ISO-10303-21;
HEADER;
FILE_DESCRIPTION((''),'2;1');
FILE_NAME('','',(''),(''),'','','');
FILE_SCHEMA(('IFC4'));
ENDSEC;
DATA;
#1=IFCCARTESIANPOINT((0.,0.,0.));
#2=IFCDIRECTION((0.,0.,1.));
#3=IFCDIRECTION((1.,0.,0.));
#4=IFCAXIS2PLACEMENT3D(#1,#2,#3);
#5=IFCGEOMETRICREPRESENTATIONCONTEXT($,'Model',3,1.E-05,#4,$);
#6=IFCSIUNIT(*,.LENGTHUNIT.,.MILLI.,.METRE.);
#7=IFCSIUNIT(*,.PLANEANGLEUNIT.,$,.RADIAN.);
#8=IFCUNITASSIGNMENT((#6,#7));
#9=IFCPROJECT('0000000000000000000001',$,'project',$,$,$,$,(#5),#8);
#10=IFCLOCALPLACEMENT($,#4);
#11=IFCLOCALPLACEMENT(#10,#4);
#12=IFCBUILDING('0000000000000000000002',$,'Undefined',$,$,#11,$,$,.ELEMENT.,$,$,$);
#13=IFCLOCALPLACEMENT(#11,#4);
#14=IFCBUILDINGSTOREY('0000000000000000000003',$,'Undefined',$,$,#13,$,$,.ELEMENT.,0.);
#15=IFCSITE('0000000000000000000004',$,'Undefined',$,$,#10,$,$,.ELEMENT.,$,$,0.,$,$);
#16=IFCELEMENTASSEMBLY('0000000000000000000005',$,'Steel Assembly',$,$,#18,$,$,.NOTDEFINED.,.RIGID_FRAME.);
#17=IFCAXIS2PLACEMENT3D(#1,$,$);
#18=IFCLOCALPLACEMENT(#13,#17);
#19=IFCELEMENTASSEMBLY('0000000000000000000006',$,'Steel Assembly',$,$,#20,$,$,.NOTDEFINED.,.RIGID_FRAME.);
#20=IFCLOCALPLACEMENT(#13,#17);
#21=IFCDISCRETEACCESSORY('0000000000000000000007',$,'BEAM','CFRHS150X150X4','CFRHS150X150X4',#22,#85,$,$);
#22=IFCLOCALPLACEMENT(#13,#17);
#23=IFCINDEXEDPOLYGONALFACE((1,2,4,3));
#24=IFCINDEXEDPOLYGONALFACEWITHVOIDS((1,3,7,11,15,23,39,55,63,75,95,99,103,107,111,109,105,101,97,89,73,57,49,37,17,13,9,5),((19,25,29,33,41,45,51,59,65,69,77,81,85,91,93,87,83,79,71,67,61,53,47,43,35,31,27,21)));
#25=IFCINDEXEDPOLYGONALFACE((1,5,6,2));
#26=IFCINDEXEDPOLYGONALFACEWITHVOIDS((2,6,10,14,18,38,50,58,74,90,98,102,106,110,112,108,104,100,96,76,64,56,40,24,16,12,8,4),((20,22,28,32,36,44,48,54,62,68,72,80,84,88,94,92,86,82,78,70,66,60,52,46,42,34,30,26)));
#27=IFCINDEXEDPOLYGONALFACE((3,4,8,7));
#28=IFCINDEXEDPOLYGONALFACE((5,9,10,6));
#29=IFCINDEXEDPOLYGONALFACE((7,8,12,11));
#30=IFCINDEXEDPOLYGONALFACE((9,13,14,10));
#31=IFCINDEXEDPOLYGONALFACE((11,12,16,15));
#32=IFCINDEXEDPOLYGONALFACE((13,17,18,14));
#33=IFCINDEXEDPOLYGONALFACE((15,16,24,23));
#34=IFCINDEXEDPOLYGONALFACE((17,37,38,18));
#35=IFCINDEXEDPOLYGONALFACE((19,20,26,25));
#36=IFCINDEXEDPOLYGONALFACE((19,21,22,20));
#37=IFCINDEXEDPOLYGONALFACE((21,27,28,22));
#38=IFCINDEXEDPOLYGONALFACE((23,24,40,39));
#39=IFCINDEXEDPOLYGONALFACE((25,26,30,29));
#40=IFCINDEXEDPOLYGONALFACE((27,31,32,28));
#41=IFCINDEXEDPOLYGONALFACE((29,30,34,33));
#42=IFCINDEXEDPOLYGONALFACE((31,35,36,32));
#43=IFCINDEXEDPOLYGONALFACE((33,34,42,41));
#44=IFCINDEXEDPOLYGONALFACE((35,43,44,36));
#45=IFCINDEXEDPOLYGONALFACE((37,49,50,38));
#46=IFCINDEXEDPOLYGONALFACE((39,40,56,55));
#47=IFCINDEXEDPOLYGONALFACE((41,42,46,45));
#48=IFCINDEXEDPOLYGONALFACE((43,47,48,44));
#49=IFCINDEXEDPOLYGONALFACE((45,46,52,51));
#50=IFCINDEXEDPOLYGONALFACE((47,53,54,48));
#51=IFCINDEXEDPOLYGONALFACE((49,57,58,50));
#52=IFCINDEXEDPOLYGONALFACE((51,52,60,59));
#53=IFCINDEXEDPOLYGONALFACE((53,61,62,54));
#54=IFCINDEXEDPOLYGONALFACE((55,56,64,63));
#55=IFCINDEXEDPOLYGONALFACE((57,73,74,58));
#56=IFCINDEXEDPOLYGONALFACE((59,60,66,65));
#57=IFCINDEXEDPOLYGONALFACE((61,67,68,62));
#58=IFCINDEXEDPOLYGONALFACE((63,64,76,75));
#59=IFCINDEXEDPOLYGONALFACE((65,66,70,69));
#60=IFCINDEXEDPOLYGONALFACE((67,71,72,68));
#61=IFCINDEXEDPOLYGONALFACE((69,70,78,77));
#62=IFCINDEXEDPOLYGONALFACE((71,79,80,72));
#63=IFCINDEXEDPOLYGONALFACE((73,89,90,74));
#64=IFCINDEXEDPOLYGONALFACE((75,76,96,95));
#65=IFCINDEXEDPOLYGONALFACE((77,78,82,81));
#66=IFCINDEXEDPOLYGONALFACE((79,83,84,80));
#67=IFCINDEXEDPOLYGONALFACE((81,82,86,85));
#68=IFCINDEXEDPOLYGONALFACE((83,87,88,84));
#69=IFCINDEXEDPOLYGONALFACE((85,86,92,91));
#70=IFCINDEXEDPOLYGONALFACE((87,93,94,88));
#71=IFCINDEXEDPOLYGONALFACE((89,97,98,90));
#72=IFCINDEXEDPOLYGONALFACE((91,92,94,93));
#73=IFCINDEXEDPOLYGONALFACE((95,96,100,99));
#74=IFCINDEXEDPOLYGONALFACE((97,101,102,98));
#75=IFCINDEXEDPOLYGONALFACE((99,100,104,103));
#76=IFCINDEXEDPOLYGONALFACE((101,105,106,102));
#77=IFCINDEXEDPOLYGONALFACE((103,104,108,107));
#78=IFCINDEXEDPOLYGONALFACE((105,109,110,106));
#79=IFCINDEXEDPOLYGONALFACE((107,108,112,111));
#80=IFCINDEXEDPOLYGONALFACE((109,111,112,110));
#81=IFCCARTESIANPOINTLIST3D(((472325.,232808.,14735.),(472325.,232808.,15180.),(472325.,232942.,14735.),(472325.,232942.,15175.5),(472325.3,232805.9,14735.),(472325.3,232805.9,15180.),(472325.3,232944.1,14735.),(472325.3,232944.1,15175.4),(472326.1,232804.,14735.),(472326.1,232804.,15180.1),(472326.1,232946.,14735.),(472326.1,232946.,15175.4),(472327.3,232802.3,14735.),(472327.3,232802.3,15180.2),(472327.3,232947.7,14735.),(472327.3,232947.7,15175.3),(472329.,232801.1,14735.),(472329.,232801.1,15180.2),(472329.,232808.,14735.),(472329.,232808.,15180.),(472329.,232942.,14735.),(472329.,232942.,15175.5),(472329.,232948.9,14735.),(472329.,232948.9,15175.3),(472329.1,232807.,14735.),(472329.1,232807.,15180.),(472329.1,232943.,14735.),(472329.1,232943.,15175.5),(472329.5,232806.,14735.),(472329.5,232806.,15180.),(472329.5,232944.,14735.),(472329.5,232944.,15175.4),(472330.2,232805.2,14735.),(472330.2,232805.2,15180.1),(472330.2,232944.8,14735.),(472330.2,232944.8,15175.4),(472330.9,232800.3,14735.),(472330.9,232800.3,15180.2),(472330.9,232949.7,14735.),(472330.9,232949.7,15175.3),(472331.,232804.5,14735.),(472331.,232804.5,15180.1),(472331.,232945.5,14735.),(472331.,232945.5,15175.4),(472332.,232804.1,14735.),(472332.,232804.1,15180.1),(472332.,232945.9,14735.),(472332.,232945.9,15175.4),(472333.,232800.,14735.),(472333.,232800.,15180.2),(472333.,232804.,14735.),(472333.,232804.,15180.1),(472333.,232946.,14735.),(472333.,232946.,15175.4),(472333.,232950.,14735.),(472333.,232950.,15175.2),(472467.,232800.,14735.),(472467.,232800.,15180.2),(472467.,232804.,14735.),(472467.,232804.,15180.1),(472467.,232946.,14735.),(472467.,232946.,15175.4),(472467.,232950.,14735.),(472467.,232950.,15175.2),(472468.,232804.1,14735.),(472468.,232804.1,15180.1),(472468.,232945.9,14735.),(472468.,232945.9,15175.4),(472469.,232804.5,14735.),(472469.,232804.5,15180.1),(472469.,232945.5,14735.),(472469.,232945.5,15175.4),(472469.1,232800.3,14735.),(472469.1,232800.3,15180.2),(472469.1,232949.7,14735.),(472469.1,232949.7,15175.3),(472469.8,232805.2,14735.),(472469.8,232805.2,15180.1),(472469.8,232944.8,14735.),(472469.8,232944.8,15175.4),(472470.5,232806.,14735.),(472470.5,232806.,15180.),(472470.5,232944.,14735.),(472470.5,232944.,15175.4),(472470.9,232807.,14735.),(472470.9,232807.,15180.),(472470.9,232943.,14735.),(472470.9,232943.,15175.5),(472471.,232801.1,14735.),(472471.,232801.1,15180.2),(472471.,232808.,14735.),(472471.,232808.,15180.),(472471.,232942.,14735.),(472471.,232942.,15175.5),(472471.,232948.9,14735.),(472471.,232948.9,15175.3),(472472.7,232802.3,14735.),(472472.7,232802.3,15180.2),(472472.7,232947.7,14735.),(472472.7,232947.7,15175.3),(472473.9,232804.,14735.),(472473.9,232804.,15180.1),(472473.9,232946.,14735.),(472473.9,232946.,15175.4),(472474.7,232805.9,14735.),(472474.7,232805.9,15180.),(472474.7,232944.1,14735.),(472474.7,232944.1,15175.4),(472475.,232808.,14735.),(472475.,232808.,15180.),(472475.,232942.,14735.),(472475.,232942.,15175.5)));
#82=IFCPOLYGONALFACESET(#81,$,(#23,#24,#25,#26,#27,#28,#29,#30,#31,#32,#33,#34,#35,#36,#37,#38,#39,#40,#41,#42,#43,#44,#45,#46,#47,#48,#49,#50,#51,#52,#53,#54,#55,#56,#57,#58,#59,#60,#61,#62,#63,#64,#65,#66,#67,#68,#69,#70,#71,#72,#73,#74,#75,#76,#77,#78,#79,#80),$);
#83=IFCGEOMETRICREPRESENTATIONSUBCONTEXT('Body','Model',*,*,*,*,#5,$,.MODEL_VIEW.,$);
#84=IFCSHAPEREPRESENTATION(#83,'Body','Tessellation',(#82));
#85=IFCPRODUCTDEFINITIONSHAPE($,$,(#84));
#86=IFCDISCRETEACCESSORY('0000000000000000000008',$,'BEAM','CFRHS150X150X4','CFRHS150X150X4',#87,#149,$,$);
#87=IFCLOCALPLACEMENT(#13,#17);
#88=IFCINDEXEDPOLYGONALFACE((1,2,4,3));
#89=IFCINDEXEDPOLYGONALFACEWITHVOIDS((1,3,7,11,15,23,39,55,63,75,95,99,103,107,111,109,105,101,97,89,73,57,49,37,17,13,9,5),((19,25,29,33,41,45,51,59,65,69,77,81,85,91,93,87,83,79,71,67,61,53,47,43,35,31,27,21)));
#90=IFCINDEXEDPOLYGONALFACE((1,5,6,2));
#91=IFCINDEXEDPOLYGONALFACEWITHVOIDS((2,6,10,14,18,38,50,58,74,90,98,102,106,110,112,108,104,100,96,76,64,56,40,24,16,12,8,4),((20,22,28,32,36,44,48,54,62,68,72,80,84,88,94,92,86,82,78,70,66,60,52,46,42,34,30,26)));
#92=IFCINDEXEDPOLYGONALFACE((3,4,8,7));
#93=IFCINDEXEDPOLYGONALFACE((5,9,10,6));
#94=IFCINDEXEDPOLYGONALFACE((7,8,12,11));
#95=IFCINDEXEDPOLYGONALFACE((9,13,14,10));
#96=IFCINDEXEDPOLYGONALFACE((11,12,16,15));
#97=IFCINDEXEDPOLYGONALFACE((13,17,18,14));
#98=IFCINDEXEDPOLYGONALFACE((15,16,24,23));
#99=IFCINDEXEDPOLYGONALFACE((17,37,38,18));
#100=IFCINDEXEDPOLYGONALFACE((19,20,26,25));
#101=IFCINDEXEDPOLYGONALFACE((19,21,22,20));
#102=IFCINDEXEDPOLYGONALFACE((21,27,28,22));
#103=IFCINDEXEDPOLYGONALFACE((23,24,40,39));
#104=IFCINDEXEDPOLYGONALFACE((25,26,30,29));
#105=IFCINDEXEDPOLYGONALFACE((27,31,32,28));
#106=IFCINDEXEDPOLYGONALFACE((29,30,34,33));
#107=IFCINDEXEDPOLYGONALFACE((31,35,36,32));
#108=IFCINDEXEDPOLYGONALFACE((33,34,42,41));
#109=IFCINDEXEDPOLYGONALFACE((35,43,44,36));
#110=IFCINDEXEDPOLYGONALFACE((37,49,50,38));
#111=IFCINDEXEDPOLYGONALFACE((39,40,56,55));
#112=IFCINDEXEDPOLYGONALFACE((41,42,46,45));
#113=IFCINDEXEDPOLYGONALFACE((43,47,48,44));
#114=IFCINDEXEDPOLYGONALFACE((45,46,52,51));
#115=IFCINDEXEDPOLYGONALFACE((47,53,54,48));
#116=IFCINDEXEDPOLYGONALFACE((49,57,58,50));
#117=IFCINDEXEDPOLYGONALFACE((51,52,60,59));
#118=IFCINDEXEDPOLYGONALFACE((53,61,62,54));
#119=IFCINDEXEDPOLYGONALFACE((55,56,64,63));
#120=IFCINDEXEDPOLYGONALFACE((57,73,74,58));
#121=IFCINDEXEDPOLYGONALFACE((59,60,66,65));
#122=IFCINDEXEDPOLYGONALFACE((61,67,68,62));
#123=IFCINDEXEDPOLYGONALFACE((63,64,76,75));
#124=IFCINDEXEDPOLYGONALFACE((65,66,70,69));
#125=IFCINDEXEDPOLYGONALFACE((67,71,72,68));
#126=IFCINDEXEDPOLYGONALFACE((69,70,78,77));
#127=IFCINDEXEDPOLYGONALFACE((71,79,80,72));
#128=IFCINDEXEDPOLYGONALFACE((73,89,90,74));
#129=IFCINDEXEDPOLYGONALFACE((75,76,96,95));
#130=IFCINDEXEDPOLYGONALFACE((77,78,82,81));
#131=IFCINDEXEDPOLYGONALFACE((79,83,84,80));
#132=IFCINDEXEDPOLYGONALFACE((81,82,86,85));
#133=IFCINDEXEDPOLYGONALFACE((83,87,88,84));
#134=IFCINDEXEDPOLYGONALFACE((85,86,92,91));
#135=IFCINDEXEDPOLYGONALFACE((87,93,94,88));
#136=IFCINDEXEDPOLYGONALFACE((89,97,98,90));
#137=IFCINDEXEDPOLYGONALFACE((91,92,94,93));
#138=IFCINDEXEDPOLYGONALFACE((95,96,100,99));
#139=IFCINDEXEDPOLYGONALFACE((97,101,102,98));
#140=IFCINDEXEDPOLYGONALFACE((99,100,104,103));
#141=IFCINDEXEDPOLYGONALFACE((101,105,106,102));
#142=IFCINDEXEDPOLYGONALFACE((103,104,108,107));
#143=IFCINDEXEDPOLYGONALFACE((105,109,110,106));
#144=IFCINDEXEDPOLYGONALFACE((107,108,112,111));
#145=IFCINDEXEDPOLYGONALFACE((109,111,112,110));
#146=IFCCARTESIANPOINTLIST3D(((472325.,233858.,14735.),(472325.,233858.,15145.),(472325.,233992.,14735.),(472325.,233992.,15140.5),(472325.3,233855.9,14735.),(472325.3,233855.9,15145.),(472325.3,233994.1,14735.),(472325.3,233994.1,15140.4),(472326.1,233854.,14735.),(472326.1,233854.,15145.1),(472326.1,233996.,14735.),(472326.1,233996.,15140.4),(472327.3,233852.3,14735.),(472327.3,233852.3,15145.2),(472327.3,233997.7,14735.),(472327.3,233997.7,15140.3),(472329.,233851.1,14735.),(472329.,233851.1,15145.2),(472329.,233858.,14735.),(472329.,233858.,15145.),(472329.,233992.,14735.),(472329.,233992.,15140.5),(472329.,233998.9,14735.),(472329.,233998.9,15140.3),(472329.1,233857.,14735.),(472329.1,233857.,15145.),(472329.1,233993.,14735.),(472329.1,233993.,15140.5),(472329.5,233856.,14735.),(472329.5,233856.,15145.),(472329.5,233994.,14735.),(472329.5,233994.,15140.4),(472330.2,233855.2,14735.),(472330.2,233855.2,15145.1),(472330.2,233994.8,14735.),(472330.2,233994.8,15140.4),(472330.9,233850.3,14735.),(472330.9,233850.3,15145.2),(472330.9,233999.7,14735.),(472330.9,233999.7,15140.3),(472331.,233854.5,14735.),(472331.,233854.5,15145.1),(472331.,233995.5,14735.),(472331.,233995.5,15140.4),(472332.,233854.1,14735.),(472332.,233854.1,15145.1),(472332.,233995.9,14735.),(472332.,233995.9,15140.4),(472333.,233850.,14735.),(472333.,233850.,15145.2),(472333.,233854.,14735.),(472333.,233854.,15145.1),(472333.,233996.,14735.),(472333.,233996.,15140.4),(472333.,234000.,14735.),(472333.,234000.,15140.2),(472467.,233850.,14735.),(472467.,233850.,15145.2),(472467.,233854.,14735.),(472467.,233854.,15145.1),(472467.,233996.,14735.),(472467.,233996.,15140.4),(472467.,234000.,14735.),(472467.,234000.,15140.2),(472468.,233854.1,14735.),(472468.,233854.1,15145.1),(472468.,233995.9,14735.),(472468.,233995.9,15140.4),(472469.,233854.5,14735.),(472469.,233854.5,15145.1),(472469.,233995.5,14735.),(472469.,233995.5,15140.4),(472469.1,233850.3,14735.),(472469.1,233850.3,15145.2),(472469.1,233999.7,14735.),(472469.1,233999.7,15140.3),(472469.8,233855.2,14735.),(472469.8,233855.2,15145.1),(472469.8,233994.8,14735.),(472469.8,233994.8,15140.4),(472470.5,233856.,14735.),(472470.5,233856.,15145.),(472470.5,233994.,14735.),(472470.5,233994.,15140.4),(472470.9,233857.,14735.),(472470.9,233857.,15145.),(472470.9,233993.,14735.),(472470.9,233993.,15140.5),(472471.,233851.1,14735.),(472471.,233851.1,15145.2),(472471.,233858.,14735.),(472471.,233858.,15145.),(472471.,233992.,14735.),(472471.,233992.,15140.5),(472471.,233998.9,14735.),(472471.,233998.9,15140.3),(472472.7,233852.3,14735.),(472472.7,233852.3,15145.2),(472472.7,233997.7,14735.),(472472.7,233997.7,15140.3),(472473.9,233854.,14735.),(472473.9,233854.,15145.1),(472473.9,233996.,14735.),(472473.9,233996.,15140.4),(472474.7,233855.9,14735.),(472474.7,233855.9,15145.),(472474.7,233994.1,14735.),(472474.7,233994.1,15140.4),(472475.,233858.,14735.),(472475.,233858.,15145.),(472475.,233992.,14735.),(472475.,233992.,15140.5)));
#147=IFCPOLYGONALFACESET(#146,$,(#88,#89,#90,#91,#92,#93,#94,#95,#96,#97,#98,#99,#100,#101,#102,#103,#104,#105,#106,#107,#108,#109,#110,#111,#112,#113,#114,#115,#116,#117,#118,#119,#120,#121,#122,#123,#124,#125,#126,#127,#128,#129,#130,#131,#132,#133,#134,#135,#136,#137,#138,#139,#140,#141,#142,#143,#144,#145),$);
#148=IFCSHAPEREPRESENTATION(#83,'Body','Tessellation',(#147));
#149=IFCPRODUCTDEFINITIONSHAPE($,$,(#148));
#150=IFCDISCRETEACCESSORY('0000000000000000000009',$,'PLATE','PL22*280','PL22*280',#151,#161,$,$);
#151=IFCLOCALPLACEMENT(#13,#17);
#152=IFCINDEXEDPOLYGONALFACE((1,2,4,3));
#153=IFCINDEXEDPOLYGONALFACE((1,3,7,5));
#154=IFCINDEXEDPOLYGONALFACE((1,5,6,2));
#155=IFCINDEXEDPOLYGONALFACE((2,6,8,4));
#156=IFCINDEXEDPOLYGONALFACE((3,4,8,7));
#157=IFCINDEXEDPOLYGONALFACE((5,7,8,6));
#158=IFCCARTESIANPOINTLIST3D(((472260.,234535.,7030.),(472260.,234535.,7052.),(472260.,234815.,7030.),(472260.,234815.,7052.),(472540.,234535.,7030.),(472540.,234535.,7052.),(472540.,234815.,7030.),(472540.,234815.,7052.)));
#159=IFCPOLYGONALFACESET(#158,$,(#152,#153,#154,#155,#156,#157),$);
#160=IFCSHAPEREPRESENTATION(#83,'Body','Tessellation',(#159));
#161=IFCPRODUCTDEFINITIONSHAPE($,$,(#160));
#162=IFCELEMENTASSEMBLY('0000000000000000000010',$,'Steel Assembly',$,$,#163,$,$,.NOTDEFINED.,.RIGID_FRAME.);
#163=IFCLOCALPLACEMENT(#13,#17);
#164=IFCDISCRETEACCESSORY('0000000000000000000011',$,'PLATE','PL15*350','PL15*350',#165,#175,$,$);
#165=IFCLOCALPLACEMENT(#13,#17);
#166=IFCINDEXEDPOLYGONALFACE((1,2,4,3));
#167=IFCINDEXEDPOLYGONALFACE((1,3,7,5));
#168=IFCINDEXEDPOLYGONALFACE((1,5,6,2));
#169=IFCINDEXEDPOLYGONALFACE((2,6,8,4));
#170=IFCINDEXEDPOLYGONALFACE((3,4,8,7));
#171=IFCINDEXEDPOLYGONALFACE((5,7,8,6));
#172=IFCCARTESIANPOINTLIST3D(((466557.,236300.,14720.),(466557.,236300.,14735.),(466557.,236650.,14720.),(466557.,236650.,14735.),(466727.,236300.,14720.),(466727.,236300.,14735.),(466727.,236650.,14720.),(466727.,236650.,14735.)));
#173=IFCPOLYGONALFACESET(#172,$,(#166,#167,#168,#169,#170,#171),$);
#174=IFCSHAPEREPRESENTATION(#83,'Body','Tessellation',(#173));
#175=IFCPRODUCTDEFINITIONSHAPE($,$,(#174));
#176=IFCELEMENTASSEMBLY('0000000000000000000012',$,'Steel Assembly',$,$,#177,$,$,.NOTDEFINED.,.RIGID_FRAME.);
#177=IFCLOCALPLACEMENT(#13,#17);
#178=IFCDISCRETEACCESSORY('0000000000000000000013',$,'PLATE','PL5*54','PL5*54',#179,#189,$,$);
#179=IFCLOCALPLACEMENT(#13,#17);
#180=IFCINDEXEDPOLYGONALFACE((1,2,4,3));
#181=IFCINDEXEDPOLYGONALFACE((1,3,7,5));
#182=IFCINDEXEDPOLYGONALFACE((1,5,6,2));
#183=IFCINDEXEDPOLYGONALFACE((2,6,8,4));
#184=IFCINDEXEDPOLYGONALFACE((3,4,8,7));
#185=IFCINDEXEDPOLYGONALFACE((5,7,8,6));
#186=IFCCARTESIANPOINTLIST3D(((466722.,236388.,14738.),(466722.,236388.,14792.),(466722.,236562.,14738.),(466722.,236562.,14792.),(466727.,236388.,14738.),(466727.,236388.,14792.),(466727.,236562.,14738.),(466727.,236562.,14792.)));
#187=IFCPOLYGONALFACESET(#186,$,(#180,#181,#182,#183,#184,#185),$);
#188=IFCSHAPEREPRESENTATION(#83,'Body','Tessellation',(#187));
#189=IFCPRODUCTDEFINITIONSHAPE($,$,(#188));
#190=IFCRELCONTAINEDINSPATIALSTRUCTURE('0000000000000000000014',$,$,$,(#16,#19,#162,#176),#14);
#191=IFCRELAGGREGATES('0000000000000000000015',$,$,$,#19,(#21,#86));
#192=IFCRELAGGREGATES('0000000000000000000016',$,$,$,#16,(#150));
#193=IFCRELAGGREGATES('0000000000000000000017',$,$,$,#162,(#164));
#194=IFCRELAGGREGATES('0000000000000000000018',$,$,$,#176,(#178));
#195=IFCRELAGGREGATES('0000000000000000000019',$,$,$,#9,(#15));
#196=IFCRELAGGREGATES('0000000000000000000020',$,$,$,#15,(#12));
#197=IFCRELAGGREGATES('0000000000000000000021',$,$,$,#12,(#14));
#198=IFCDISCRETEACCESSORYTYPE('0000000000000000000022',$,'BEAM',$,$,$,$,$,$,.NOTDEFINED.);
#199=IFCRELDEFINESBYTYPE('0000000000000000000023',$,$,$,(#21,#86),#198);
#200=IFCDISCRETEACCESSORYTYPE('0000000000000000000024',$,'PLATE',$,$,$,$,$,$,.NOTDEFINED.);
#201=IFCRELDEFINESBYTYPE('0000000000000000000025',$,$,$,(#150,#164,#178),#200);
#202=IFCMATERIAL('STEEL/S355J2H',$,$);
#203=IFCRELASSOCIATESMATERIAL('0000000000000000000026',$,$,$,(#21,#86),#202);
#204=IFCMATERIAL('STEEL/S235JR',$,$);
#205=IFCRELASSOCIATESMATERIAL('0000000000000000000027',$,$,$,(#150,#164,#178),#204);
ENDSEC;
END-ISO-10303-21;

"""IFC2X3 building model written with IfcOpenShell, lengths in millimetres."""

from ifc_helpers import new_model, si_unit, frame, origin_with_axes, origin_2d_with_axis, place, context, subcontext, project, spatial, polyline, hollow_rectangle, outline, extrude, clip, halfspace, material, type_object, element, aggregate, save


model = new_model("IFC2X3")

# Units and contexts
model_context = context("Model", 3, precision=1e-05, world=origin_with_axes())
body_context = subcontext(model_context, "Body", "Model", "MODEL_VIEW")
ifc_project = project(units=[si_unit("LENGTHUNIT", "METRE", prefix="MILLI"), si_unit("PLANEANGLEUNIT", "RADIAN")], contexts=[model_context])

# Site, building, storey
site_placement = place(None, origin_with_axes())
site = spatial("IfcSite", under=ifc_project, at=site_placement, Name="Undefined", CompositionType="ELEMENT", RefElevation=0.0)
building_placement = place(site_placement, origin_with_axes())
building = spatial("IfcBuilding", under=site, at=building_placement, Name="Undefined", CompositionType="ELEMENT")
storey_placement = place(building_placement, origin_with_axes())
storey = spatial("IfcBuildingStorey", under=building, at=storey_placement, Name="Undefined", CompositionType="ELEMENT", Elevation=0.0)

# Element assembly
assembly_1_placement = place(storey_placement, origin_with_axes())
assembly_1 = element("IfcElementAssembly", 1, at=assembly_1_placement, inside=storey, Name="Steel Assembly", AssemblyPlace="NOTDEFINED", PredefinedType="RIGID_FRAME")
ifc_material_1 = material(Name="STEEL/S235JR")

# Shared definitions
ifc_material_2 = material(Name="STEEL/S355J2H")

# Element assembly, discrete accessories
assembly_2_placement = place(storey_placement, origin_with_axes())
assembly_2 = element("IfcElementAssembly", 2, at=assembly_2_placement, inside=storey, Name="Steel Assembly", AssemblyPlace="NOTDEFINED", PredefinedType="RIGID_FRAME")
discrete_accessory_type_1 = type_object("IfcDiscreteAccessoryType", Name="BEAM")
discrete_accessory_1_placement = place(assembly_2_placement, frame((472400.0, 232875.0, 14720.0), z_axis=(0.0, 0.0, 1.0), x_axis=(1.0, 0.0, 0.0)))
discrete_accessory_1 = element("IfcDiscreteAccessory", 3, at=discrete_accessory_1_placement, type_object=discrete_accessory_type_1, material=ifc_material_2, Name="BEAM", Description="CFRHS150X150X4", ObjectType="CFRHS150X150X4", context=body_context, shape_type="Clipping", body=[
    clip(extrude(hollow_rectangle(XDim=150.0, YDim=150.0, WallThickness=4.0, InnerFilletRadius=4.0, OuterFilletRadius=8.0, at=origin_2d_with_axis()), frame((0.0, 0.0, 460.3), z_axis=(0.0, 0.0, -1.0), x_axis=(0.0, -1.0, 0.0)), (0.0, 0.0, 1.0), 445.3), halfspace(frame((-1000.0, -2.7, 457.8), z_axis=(0.0, -0.033315, -0.999445), x_axis=(0.0, -0.999445, 0.033315)), True)),
])
discrete_accessory_2_placement = place(assembly_2_placement, frame((472400.0, 233925.0, 14720.0), z_axis=(0.0, 0.0, 1.0), x_axis=(1.0, 0.0, 0.0)))
discrete_accessory_2 = element("IfcDiscreteAccessory", 4, at=discrete_accessory_2_placement, type_object=discrete_accessory_type_1, material=ifc_material_2, Name="BEAM", Description="CFRHS150X150X4", ObjectType="CFRHS150X150X4", context=body_context, shape_type="Clipping", body=[
    clip(extrude(hollow_rectangle(XDim=150.0, YDim=150.0, WallThickness=4.0, InnerFilletRadius=4.0, OuterFilletRadius=8.0, at=origin_2d_with_axis()), frame((0.0, 0.0, 425.3), z_axis=(0.0, 0.0, -1.0), x_axis=(0.0, -1.0, 0.0)), (0.0, 0.0, 1.0), 410.3), halfspace(frame((-1000.0, -2.7, 422.8), z_axis=(0.0, -0.033315, -0.999445), x_axis=(0.0, -0.999445, 0.033315)), True)),
])
aggregate(assembly_2, [discrete_accessory_1, discrete_accessory_2])

# Discrete accessory
discrete_accessory_type_2 = type_object("IfcDiscreteAccessoryType", Name="PLATE")
discrete_accessory_3_placement = place(assembly_1_placement, frame((472400.0, 234535.0, 7041.0), z_axis=(0.0, 0.0, 1.0), x_axis=(0.0, 1.0, 0.0)))
discrete_accessory_3 = element("IfcDiscreteAccessory", 5, at=discrete_accessory_3_placement, type_object=discrete_accessory_type_2, material=ifc_material_1, Name="PLATE", Description="PL22*280", ObjectType="PL22*280", context=body_context, shape_type="SweptSolid", body=[
    extrude(outline(polyline([(280.0, 140.0), (280.0, -140.0), (0.0, -140.0), (0.0, 140.0), (280.0, 140.0)])), frame((0.0, 0.0, -11.0), z_axis=(0.0, 0.0, 1.0), x_axis=(1.0, 0.0, 0.0)), (0.0, 0.0, 1.0), 22.0),
])
aggregate(assembly_1, [discrete_accessory_3])

# Element assemblies, discrete accessories
assembly_3_placement = place(storey_placement, origin_with_axes())
assembly_3 = element("IfcElementAssembly", 6, at=assembly_3_placement, inside=storey, Name="Steel Assembly", AssemblyPlace="NOTDEFINED", PredefinedType="RIGID_FRAME")
discrete_accessory_4_placement = place(assembly_3_placement, frame((466727.0, 236475.0, 14727.5), z_axis=(0.0, 0.0, 1.0), x_axis=(-1.0, 0.0, 0.0)))
discrete_accessory_4 = element("IfcDiscreteAccessory", 7, at=discrete_accessory_4_placement, type_object=discrete_accessory_type_2, material=ifc_material_1, Name="PLATE", Description="PL15*350", ObjectType="PL15*350", context=body_context, shape_type="SweptSolid", body=[
    extrude(outline(polyline([(170.0, -175.0), (0.0, -175.0), (0.0, 175.0), (170.0, 175.0), (170.0, -175.0)])), frame((0.0, 0.0, -7.5), z_axis=(0.0, 0.0, 1.0), x_axis=(1.0, 0.0, 0.0)), (0.0, 0.0, 1.0), 15.0),
])
aggregate(assembly_3, [discrete_accessory_4])
assembly_4_placement = place(storey_placement, origin_with_axes())
assembly_4 = element("IfcElementAssembly", 8, at=assembly_4_placement, inside=storey, Name="Steel Assembly", AssemblyPlace="NOTDEFINED", PredefinedType="RIGID_FRAME")
discrete_accessory_5_placement = place(assembly_4_placement, frame((466724.5, 236388.0, 14765.0), z_axis=(-1.0, 0.0, 0.0), x_axis=(0.0, 1.0, 0.0)))
discrete_accessory_5 = element("IfcDiscreteAccessory", 9, at=discrete_accessory_5_placement, type_object=discrete_accessory_type_2, material=ifc_material_1, Name="PLATE", Description="PL5*54", ObjectType="PL5*54", context=body_context, shape_type="SweptSolid", body=[
    extrude(outline(polyline([(174.0, 27.0), (174.0, -27.0), (0.0, -27.0), (0.0, 27.0), (174.0, 27.0)])), frame((0.0, 0.0, -2.5), z_axis=(0.0, 0.0, 1.0), x_axis=(1.0, 0.0, 0.0)), (0.0, 0.0, 1.0), 5.0),
])

aggregate(assembly_4, [discrete_accessory_5])

save(model, "model.ifc")
